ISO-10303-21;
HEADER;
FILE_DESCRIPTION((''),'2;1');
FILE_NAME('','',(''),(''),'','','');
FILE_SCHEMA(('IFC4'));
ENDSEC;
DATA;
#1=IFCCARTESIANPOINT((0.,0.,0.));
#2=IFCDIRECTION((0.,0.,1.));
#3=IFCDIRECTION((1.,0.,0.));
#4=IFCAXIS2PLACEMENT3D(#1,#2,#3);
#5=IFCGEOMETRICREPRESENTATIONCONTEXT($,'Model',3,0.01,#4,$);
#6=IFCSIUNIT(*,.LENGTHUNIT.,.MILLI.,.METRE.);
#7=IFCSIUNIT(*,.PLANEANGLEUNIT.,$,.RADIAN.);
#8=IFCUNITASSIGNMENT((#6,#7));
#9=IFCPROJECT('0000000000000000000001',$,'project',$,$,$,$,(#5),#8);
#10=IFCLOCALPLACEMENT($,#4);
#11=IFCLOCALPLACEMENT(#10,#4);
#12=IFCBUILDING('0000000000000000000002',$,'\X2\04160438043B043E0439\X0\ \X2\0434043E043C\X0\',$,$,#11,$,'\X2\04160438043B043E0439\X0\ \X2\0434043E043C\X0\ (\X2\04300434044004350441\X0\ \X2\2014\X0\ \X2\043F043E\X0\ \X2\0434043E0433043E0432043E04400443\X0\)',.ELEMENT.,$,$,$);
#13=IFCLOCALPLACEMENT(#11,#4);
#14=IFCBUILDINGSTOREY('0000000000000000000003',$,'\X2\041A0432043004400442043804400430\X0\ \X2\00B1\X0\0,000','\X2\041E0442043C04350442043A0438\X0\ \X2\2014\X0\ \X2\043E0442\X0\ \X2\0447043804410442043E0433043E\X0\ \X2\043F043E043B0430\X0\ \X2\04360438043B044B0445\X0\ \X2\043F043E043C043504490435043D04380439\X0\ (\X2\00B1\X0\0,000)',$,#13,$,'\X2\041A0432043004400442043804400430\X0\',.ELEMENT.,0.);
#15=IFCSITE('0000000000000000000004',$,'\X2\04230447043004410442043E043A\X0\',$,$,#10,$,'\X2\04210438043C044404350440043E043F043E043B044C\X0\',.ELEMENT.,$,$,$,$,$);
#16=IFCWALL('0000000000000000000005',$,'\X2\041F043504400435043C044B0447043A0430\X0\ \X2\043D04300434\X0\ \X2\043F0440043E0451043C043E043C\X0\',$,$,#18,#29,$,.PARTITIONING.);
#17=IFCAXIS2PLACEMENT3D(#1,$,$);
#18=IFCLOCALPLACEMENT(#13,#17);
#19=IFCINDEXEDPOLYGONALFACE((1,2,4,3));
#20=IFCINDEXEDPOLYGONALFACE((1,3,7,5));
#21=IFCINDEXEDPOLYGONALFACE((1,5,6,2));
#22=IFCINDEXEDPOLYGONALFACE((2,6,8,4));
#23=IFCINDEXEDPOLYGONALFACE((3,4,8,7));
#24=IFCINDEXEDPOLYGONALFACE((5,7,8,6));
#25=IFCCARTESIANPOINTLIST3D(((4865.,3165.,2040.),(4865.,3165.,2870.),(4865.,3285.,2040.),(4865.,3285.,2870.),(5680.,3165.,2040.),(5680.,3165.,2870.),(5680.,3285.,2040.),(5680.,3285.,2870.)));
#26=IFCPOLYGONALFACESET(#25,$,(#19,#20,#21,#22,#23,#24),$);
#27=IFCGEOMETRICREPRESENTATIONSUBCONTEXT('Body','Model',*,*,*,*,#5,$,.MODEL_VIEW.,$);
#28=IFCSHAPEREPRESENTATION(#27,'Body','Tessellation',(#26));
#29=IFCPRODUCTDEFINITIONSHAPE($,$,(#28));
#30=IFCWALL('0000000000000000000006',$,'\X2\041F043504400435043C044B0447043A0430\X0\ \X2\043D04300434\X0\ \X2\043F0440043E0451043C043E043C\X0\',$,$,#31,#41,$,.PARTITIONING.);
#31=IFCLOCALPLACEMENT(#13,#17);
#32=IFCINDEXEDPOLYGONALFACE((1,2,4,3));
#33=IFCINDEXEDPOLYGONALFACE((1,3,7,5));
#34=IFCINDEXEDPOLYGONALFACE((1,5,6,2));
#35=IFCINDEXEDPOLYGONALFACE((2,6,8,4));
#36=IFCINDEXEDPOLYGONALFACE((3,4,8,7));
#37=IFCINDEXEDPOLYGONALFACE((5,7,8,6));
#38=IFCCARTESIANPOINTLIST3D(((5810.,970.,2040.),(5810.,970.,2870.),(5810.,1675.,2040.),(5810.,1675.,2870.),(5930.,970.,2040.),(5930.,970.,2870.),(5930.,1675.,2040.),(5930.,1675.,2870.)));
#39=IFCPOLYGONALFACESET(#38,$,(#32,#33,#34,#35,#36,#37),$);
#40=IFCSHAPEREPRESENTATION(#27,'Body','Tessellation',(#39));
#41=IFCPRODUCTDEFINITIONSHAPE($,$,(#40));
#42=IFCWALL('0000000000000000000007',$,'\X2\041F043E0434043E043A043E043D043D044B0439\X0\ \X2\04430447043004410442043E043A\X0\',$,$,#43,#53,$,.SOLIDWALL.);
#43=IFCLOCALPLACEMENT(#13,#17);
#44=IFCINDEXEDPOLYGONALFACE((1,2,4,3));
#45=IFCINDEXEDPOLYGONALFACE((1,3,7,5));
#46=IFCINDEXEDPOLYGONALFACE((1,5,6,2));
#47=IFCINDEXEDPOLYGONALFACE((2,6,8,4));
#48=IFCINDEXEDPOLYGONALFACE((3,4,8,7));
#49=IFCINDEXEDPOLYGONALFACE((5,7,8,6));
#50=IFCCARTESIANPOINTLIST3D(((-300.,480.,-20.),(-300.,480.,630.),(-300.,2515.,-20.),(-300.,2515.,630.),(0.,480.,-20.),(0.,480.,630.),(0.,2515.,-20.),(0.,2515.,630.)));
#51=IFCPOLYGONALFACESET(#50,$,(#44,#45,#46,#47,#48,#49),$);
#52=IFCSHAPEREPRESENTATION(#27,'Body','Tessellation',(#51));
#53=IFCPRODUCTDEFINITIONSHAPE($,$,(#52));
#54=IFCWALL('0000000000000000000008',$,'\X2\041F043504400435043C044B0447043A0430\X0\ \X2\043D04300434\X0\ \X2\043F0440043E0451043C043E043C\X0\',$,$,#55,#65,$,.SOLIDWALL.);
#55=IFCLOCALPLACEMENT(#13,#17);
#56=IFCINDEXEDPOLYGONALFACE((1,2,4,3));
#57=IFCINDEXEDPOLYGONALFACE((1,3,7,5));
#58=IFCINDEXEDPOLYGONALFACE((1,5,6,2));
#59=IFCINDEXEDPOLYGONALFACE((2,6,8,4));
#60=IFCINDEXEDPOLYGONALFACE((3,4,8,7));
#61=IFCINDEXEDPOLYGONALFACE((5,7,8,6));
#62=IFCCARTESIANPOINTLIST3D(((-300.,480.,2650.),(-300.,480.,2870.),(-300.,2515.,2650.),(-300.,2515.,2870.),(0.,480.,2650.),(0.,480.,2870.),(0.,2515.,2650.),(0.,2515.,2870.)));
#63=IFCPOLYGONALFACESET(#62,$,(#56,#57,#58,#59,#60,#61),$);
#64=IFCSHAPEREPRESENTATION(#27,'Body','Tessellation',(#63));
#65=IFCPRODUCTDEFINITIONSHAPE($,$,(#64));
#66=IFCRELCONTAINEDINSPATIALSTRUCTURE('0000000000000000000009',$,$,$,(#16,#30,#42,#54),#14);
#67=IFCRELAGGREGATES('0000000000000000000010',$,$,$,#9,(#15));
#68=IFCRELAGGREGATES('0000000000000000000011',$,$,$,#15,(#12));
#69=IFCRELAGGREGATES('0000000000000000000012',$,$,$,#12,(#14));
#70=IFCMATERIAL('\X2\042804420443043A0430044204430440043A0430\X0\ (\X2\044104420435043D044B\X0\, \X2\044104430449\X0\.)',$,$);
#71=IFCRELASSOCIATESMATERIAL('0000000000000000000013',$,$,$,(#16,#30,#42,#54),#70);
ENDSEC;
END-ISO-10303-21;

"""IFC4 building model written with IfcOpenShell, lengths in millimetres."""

from ifc_helpers import new_model, si_unit, frame, origin, origin_with_axes, place, context, subcontext, project, spatial, polyline, outline, extrude, material, element, save


model = new_model("IFC4")

# Units and contexts
model_context = context("Model", 3, precision=0.01, world=origin_with_axes())
body_context = subcontext(model_context, "Body", "Model", "MODEL_VIEW")
ifc_project = project(units=[si_unit("LENGTHUNIT", "METRE", prefix="MILLI"), si_unit("PLANEANGLEUNIT", "RADIAN")], contexts=[model_context])

# Site, building, storey
site_placement = place(None, origin_with_axes())
site = spatial("IfcSite", under=ifc_project, at=site_placement, Name="Участок", LongName="Симферополь", CompositionType="ELEMENT")
building_placement = place(site_placement, origin_with_axes())
building = spatial("IfcBuilding", under=site, at=building_placement, Name="Жилой дом", LongName="Жилой дом (адрес — по договору)", CompositionType="ELEMENT")
storey_placement = place(building_placement, origin_with_axes())
storey = spatial("IfcBuildingStorey", under=building, at=storey_placement, Name="Квартира ±0,000", Description="Отметки — от чистого пола жилых помещений (±0,000)", LongName="Квартира", CompositionType="ELEMENT", Elevation=0.0)

# Walls
ifc_material_1 = material(Name="Штукатурка (стены, сущ.)")
wall_1_placement = place(storey_placement, frame((4865.0, 3165.0, 2040.0)))
element("IfcWall", 1, at=wall_1_placement, inside=storey, material=ifc_material_1, Name="Перемычка над проёмом", PredefinedType="PARTITIONING", context=body_context, shape_type="SweptSolid", body=[
    extrude(outline(polyline([(0.0, 0.0), (815.0, 0.0), (815.0, 120.0), (0.0, 120.0), (0.0, 0.0)])), origin(), (0.0, 0.0, 1.0), 830.0),
])
wall_2_placement = place(storey_placement, frame((5810.0, 970.0, 2040.0)))
element("IfcWall", 2, at=wall_2_placement, inside=storey, material=ifc_material_1, Name="Перемычка над проёмом", PredefinedType="PARTITIONING", context=body_context, shape_type="SweptSolid", body=[
    extrude(outline(polyline([(0.0, 0.0), (120.0, 0.0), (120.0, 705.0), (0.0, 705.0), (0.0, 0.0)])), origin(), (0.0, 0.0, 1.0), 830.0),
])
wall_3_placement = place(storey_placement, frame((-300.0, 480.0, -20.0)))
element("IfcWall", 3, at=wall_3_placement, inside=storey, material=ifc_material_1, Name="Подоконный участок", PredefinedType="SOLIDWALL", context=body_context, shape_type="SweptSolid", body=[
    extrude(outline(polyline([(0.0, 0.0), (300.0, 0.0), (300.0, 2035.0), (0.0, 2035.0), (0.0, 0.0)])), origin(), (0.0, 0.0, 1.0), 650.0),
])
wall_4_placement = place(storey_placement, frame((-300.0, 480.0, 2650.0)))
element("IfcWall", 4, at=wall_4_placement, inside=storey, material=ifc_material_1, Name="Перемычка над проёмом", PredefinedType="SOLIDWALL", context=body_context, shape_type="SweptSolid", body=[
    extrude(outline(polyline([(0.0, 0.0), (300.0, 0.0), (300.0, 2035.0), (0.0, 2035.0), (0.0, 0.0)])), origin(), (0.0, 0.0, 1.0), 220.0),
])

save(model, "model.ifc")
